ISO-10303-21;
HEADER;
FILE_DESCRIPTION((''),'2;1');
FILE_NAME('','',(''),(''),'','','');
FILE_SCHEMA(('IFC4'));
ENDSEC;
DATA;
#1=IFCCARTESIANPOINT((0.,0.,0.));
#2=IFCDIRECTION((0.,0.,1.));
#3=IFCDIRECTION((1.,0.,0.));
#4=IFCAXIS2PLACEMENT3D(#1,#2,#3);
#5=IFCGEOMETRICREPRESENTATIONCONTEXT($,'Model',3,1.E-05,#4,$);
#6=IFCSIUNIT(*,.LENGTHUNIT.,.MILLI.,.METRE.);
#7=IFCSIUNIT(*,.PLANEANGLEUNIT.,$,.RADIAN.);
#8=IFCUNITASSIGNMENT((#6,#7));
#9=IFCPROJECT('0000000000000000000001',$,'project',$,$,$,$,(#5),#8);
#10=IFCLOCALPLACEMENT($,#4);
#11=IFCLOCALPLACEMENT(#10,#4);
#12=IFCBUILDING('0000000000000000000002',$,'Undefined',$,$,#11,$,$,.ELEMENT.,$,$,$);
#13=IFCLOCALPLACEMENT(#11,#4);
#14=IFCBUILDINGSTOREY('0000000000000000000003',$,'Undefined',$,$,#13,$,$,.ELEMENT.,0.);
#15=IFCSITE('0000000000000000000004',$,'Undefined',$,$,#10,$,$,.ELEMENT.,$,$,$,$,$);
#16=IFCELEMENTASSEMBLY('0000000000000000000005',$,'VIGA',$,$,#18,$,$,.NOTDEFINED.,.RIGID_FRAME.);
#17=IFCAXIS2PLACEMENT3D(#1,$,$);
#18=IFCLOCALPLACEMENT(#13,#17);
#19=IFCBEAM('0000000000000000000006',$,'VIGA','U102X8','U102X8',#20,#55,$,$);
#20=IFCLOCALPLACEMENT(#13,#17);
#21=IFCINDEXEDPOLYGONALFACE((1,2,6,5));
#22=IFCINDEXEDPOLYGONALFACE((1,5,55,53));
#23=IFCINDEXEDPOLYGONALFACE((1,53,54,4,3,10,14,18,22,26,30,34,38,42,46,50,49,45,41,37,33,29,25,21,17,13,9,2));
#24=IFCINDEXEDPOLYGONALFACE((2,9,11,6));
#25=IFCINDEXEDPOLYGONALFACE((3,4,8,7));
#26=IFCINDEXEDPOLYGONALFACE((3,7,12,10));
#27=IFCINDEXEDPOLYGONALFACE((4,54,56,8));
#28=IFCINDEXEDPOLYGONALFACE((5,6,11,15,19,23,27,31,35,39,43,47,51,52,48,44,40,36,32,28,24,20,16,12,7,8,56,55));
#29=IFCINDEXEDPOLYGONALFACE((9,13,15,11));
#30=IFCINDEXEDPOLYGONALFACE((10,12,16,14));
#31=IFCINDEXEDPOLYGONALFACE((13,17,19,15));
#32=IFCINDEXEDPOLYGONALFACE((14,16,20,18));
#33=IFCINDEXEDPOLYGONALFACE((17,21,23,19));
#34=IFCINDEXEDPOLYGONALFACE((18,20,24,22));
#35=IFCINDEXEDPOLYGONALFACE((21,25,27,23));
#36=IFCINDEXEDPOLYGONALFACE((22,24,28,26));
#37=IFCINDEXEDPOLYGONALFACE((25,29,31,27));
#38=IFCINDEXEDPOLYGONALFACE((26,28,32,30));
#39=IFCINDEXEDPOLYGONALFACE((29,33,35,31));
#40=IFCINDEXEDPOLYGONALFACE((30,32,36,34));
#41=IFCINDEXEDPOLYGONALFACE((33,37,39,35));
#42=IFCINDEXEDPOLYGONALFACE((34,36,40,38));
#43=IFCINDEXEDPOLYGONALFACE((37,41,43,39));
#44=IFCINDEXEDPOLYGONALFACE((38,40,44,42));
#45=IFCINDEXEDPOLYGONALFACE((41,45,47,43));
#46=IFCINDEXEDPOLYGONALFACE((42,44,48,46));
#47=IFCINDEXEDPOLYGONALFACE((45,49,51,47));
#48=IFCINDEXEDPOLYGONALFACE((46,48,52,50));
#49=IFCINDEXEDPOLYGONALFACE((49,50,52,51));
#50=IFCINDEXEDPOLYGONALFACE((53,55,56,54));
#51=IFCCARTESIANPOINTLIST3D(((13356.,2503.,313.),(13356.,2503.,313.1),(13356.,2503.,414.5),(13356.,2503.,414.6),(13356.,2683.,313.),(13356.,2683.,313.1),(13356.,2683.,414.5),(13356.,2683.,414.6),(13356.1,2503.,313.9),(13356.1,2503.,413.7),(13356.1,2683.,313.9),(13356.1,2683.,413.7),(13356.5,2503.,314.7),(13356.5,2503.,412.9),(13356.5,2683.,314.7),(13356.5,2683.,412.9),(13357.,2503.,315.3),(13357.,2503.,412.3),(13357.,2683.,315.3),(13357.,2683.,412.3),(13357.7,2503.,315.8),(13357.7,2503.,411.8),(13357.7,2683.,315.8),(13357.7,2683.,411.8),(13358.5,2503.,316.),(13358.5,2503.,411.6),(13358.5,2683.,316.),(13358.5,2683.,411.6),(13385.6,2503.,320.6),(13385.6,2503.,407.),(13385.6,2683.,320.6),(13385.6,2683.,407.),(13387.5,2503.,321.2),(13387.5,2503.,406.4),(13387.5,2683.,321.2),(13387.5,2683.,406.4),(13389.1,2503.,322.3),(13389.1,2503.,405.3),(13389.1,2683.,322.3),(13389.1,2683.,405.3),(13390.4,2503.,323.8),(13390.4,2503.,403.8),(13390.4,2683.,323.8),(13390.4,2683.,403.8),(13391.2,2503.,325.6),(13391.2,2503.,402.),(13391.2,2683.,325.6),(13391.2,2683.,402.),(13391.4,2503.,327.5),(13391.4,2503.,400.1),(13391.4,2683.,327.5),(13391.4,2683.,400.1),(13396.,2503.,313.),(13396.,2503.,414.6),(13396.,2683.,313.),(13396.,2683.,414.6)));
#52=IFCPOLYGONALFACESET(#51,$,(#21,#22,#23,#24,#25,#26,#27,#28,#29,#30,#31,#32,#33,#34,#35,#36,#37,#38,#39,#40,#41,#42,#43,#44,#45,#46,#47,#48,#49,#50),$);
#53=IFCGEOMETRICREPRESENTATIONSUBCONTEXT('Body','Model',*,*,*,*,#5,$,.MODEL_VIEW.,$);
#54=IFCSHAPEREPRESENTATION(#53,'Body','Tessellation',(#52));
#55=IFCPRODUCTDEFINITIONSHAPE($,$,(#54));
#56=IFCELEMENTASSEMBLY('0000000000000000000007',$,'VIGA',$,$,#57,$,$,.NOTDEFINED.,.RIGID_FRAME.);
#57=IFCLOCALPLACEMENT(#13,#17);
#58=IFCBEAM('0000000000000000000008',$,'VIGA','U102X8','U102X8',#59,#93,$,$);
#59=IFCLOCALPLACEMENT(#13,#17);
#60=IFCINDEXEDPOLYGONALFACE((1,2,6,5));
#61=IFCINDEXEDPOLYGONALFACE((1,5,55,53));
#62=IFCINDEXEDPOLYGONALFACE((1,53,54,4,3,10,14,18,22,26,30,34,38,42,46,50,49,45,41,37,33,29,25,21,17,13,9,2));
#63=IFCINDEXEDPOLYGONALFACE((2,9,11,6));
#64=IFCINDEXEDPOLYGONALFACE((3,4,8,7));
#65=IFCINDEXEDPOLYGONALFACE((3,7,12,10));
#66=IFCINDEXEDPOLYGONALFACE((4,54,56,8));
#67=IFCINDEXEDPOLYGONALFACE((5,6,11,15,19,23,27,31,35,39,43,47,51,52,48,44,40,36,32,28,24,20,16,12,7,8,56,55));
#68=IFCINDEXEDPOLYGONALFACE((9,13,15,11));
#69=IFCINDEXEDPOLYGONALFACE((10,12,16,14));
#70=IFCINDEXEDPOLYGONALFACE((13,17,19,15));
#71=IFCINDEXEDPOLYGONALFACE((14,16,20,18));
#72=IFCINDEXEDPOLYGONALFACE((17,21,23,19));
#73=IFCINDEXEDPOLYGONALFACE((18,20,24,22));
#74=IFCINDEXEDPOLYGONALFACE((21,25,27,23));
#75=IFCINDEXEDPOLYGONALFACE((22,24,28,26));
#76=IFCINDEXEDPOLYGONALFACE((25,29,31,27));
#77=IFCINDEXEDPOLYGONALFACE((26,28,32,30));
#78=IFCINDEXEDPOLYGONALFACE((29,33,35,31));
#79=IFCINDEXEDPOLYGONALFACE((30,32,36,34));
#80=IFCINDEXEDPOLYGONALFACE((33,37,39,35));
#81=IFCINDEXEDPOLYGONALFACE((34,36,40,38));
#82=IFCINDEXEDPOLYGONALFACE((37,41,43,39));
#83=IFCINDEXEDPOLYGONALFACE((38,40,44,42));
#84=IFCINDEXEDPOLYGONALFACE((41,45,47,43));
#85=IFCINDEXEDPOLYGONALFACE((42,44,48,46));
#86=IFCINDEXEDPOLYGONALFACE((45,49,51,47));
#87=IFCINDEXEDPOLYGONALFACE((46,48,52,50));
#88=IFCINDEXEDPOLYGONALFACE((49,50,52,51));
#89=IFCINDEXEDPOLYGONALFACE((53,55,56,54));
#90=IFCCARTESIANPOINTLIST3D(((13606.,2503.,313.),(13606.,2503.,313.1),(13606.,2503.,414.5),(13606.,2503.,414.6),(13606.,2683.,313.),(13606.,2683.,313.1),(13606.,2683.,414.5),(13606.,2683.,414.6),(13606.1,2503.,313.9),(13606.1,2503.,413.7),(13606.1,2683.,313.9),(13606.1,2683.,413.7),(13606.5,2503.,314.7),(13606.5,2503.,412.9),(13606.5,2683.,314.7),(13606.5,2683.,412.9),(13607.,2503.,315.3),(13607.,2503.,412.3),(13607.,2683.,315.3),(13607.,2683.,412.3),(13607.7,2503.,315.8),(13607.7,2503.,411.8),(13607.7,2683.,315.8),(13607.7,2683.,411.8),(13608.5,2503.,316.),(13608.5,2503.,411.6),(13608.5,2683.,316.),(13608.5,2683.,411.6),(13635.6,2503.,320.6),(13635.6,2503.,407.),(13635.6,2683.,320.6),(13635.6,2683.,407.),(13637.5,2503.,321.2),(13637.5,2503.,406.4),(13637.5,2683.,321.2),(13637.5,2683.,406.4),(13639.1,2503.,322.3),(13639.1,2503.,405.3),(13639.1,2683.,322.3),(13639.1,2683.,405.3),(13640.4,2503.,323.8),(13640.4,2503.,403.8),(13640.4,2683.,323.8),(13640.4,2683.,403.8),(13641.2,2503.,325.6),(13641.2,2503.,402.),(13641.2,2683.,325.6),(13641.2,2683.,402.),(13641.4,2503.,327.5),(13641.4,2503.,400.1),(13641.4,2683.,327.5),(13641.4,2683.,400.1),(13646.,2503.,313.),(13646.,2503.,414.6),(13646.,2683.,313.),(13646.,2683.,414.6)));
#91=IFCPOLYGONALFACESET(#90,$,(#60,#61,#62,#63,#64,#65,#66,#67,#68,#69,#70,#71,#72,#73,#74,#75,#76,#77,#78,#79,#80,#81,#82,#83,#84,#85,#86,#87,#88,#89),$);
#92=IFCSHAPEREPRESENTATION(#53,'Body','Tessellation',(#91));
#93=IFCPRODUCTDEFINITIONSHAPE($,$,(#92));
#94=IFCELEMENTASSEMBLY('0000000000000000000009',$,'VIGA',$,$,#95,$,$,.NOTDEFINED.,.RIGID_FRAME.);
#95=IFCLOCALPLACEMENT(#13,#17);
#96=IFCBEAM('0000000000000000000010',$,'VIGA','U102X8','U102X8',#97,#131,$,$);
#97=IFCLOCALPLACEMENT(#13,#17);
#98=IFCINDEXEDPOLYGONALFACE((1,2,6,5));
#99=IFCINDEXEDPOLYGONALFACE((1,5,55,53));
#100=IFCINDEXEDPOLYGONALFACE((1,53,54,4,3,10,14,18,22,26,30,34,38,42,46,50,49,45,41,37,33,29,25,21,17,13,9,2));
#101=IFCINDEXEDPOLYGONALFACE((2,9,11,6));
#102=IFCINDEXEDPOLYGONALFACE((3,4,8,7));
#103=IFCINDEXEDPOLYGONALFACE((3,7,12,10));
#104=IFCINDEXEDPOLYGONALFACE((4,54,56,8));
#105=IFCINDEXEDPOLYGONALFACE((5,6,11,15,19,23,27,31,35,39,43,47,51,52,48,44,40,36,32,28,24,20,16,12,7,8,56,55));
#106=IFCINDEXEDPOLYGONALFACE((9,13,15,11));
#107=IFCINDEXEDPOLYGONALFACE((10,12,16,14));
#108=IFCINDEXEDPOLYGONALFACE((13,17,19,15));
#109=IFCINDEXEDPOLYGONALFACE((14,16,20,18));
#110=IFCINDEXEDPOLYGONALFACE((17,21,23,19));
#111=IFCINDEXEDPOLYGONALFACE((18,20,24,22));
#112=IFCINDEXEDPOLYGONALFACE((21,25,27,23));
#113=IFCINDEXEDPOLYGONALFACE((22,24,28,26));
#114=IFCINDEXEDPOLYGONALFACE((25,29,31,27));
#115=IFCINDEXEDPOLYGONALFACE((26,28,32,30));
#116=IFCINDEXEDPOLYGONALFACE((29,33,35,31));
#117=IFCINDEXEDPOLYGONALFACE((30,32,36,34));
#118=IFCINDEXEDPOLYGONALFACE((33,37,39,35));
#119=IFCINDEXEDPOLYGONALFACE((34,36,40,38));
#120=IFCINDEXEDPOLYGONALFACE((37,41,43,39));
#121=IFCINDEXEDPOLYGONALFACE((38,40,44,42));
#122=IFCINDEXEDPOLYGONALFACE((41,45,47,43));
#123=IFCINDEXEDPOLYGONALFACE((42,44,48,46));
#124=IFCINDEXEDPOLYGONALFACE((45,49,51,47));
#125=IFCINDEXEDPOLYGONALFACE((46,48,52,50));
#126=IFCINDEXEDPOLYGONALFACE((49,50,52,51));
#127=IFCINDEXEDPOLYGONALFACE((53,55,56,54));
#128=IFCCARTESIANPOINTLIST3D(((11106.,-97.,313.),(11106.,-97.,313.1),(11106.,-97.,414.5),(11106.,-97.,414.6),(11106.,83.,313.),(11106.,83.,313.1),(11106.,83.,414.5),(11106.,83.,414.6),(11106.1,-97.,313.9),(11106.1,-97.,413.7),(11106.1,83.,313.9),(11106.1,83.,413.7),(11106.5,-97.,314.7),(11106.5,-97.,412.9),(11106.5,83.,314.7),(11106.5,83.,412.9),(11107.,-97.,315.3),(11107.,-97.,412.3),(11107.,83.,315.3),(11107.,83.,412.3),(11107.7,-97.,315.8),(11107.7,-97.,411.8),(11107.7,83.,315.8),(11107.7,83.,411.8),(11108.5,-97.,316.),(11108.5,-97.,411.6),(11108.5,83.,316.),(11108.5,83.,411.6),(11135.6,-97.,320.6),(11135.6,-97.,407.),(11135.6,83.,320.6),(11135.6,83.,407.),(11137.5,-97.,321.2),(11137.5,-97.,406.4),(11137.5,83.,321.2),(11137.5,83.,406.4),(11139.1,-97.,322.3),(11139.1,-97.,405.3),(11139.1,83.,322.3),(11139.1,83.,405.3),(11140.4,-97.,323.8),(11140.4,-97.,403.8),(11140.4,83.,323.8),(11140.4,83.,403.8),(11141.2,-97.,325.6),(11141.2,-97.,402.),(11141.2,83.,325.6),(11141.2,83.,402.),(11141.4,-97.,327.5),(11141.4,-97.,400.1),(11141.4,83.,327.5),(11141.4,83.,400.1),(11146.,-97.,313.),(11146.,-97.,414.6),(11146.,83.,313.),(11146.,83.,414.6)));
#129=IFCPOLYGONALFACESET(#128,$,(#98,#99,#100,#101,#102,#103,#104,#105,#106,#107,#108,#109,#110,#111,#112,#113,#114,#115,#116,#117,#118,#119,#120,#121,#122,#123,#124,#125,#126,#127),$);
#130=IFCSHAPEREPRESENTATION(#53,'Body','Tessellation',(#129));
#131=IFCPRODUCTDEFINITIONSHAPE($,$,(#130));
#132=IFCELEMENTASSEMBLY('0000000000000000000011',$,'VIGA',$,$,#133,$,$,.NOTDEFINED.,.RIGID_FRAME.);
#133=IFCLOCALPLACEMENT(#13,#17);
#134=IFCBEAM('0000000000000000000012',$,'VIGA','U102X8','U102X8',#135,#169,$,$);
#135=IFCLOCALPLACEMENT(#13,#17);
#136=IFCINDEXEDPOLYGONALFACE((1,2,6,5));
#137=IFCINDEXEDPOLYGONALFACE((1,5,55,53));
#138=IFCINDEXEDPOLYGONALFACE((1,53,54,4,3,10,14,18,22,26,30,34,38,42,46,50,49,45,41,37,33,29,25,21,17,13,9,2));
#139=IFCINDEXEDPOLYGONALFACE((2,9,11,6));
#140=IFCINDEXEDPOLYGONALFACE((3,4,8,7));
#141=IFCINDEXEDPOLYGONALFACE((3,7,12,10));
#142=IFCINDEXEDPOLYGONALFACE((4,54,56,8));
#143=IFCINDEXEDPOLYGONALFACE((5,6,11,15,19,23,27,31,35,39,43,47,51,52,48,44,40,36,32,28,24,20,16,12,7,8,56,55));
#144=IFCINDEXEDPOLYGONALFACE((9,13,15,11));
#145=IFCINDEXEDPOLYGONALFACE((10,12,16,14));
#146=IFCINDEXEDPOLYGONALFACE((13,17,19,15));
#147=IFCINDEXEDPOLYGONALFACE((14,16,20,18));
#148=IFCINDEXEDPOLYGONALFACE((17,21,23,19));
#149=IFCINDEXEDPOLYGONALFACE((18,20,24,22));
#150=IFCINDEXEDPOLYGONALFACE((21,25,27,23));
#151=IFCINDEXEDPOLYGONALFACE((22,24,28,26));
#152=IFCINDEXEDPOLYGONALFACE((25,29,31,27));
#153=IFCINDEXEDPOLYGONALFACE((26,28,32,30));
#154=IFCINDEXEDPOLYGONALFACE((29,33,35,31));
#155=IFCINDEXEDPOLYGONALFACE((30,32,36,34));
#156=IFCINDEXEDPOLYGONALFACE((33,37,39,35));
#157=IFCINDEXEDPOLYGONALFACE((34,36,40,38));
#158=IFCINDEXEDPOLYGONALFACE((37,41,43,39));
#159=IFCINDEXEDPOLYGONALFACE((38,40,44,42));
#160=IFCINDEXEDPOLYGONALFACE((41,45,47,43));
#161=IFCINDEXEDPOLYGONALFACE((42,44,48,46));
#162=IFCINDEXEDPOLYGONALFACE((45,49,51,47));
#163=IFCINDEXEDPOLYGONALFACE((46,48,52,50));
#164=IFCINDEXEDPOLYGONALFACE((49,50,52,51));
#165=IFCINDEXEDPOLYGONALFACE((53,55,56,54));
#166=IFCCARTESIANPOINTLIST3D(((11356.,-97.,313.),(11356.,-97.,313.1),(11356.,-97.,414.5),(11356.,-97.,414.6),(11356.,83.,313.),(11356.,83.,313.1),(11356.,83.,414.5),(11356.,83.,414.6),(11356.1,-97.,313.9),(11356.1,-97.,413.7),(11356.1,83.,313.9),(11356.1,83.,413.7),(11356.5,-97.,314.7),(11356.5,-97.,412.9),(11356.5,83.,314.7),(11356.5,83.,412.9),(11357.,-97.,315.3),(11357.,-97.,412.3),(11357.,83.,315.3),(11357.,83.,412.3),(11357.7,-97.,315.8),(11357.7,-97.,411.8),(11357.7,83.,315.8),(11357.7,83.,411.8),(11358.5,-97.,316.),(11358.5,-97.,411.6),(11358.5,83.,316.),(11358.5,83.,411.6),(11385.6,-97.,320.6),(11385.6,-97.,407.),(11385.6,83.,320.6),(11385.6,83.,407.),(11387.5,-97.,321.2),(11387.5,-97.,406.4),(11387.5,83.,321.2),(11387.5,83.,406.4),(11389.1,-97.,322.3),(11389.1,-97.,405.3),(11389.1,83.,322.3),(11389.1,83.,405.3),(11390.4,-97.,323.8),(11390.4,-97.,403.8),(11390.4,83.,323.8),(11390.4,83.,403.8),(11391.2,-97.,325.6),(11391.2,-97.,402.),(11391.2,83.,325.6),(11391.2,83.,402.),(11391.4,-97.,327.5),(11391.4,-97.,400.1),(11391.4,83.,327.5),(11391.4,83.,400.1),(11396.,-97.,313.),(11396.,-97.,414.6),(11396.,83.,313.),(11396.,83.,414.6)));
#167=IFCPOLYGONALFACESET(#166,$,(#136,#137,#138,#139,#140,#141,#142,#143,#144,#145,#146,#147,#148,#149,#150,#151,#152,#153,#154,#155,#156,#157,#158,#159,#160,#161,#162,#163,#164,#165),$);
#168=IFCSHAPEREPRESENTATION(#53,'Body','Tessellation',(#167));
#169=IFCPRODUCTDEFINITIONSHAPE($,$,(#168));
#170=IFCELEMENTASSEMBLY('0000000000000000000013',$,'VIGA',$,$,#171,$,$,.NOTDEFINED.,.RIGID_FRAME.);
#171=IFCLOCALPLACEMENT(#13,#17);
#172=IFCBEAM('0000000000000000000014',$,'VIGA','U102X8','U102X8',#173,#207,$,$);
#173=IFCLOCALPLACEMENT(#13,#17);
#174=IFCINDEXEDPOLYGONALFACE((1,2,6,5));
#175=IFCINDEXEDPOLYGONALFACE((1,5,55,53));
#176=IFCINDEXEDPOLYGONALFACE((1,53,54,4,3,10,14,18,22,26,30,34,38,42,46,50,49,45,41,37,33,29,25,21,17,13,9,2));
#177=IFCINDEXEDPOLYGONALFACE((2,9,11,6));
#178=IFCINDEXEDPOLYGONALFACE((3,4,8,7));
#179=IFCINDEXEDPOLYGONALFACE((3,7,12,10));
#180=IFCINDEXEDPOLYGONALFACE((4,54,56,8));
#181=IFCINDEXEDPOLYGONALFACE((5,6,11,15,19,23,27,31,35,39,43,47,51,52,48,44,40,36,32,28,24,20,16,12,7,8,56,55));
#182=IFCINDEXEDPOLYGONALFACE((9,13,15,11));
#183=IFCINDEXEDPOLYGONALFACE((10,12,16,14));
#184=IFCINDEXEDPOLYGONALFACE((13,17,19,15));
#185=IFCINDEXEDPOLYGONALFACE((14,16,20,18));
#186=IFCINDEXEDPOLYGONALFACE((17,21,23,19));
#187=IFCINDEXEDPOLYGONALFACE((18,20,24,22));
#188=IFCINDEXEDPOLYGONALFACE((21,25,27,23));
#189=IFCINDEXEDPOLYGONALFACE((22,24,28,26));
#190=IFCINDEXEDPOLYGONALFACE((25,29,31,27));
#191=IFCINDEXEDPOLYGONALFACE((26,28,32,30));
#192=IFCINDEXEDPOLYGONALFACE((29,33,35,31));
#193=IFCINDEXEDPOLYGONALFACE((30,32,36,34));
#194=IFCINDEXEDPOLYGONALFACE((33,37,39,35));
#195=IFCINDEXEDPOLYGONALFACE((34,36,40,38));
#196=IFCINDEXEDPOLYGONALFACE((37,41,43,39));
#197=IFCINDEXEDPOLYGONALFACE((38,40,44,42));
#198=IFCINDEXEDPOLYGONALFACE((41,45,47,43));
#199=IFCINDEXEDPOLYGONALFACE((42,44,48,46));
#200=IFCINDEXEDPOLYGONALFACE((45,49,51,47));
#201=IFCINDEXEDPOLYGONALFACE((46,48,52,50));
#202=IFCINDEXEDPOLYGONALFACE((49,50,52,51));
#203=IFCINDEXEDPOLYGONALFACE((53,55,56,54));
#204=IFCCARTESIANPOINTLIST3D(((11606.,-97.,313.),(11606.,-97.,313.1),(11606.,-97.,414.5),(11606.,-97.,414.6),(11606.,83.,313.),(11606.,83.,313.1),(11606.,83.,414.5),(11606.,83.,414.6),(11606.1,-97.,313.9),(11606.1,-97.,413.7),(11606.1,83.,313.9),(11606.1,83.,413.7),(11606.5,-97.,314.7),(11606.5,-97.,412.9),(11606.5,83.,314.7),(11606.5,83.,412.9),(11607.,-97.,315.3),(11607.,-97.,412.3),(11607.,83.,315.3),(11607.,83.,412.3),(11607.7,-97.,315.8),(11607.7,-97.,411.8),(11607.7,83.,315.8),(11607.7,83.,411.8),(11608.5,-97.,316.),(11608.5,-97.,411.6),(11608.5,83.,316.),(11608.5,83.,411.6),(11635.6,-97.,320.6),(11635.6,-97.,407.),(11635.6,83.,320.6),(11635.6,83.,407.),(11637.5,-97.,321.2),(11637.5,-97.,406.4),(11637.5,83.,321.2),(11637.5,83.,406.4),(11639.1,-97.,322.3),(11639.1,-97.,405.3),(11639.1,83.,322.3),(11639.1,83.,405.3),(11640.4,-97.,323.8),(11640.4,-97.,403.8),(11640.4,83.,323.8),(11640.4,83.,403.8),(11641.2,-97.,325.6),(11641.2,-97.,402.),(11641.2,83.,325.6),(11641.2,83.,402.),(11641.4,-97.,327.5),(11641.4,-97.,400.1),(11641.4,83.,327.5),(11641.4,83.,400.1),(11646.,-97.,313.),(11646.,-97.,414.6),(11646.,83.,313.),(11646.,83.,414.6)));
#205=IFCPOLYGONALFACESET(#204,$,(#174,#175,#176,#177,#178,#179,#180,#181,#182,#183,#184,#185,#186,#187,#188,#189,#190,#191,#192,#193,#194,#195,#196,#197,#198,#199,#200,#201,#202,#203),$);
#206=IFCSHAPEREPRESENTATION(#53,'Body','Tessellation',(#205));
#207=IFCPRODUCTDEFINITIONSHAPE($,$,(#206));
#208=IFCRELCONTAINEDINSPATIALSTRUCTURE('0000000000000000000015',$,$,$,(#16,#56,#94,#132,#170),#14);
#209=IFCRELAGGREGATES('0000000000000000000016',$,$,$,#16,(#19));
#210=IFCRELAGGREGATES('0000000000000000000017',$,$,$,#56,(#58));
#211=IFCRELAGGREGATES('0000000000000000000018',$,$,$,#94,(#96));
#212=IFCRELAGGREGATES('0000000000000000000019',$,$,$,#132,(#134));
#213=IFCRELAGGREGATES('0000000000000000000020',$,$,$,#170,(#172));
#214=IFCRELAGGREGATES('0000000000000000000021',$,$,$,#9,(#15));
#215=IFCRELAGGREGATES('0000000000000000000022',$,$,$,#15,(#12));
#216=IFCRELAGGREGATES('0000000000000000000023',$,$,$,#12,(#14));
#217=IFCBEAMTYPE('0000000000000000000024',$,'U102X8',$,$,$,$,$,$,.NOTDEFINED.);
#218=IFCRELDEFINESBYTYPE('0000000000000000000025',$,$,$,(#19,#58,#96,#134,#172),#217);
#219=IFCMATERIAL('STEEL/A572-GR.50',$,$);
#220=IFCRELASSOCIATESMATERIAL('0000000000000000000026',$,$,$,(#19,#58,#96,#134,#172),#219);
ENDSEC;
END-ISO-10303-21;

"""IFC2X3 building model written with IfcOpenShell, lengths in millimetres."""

from ifc_helpers import new_model, si_unit, frame, origin_with_axes, origin_2d_with_axis, place, context, subcontext, project, spatial, u_section, extrude, material, type_object, element, aggregate, save


model = new_model("IFC2X3")

# Units and contexts
model_context = context("Model", 3, precision=1e-05, world=origin_with_axes())
body_context = subcontext(model_context, "Body", "Model", "MODEL_VIEW")
ifc_project = project(units=[si_unit("LENGTHUNIT", "METRE", prefix="MILLI"), si_unit("PLANEANGLEUNIT", "RADIAN")], contexts=[model_context])

# Site, building, storey
site_placement = place(None, origin_with_axes())
site = spatial("IfcSite", under=ifc_project, at=site_placement, Name="Undefined", CompositionType="ELEMENT")
building_placement = place(site_placement, origin_with_axes())
building = spatial("IfcBuilding", under=site, at=building_placement, Name="Undefined", CompositionType="ELEMENT")
storey_placement = place(building_placement, origin_with_axes())
storey = spatial("IfcBuildingStorey", under=building, at=storey_placement, Name="Undefined", CompositionType="ELEMENT", Elevation=0.0)

# Element assemblies, beams
ifc_material = material(Name="STEEL/A572-GR.50")
beam_type = type_object("IfcBeamType", Name="U102X8", PredefinedType="NOTDEFINED")
assembly_1_placement = place(storey_placement, origin_with_axes())
assembly_1 = element("IfcElementAssembly", 1, at=assembly_1_placement, inside=storey, Name="VIGA", AssemblyPlace="NOTDEFINED", PredefinedType="RIGID_FRAME")
beam_1_placement = place(assembly_1_placement, frame((13376.0, 2683.0, 363.8), z_axis=(0.0, 0.0, 1.0), x_axis=(0.0, -1.0, 0.0)))
beam_1 = element("IfcBeam", 2, at=beam_1_placement, type_object=beam_type, material=ifc_material, Name="VIGA", Description="U102X8", ObjectType="U102X8", context=body_context, shape_type="SweptSolid", body=[
    extrude(u_section(Depth=101.6, FlangeWidth=40.0, WebThickness=4.6, FlangeThickness=6.0, FilletRadius=7.0, EdgeRadius=3.0, FlangeSlope=0.16839, at=origin_2d_with_axis()), frame((180.0, 0.0, 0.0), z_axis=(-1.0, 0.0, 0.0), x_axis=(0.0, -1.0, 0.0)), (0.0, 0.0, 1.0), 180.0),
])
aggregate(assembly_1, [beam_1])
assembly_2_placement = place(storey_placement, origin_with_axes())
assembly_2 = element("IfcElementAssembly", 3, at=assembly_2_placement, inside=storey, Name="VIGA", AssemblyPlace="NOTDEFINED", PredefinedType="RIGID_FRAME")
beam_2_placement = place(assembly_2_placement, frame((13626.0, 2683.0, 363.8), z_axis=(0.0, 0.0, 1.0), x_axis=(0.0, -1.0, 0.0)))
beam_2 = element("IfcBeam", 4, at=beam_2_placement, type_object=beam_type, material=ifc_material, Name="VIGA", Description="U102X8", ObjectType="U102X8", context=body_context, shape_type="SweptSolid", body=[
    extrude(u_section(Depth=101.6, FlangeWidth=40.0, WebThickness=4.6, FlangeThickness=6.0, FilletRadius=7.0, EdgeRadius=3.0, FlangeSlope=0.16839, at=origin_2d_with_axis()), frame((180.0, 0.0, 0.0), z_axis=(-1.0, 0.0, 0.0), x_axis=(0.0, -1.0, 0.0)), (0.0, 0.0, 1.0), 180.0),
])
aggregate(assembly_2, [beam_2])
assembly_3_placement = place(storey_placement, origin_with_axes())
assembly_3 = element("IfcElementAssembly", 5, at=assembly_3_placement, inside=storey, Name="VIGA", AssemblyPlace="NOTDEFINED", PredefinedType="RIGID_FRAME")
beam_3_placement = place(assembly_3_placement, frame((11126.0, 83.0, 363.8), z_axis=(0.0, 0.0, 1.0), x_axis=(0.0, -1.0, 0.0)))
beam_3 = element("IfcBeam", 6, at=beam_3_placement, type_object=beam_type, material=ifc_material, Name="VIGA", Description="U102X8", ObjectType="U102X8", context=body_context, shape_type="SweptSolid", body=[
    extrude(u_section(Depth=101.6, FlangeWidth=40.0, WebThickness=4.6, FlangeThickness=6.0, FilletRadius=7.0, EdgeRadius=3.0, FlangeSlope=0.16839, at=origin_2d_with_axis()), frame((180.0, 0.0, 0.0), z_axis=(-1.0, 0.0, 0.0), x_axis=(0.0, -1.0, 0.0)), (0.0, 0.0, 1.0), 180.0),
])
aggregate(assembly_3, [beam_3])
assembly_4_placement = place(storey_placement, origin_with_axes())
assembly_4 = element("IfcElementAssembly", 7, at=assembly_4_placement, inside=storey, Name="VIGA", AssemblyPlace="NOTDEFINED", PredefinedType="RIGID_FRAME")
beam_4_placement = place(assembly_4_placement, frame((11376.0, 83.0, 363.8), z_axis=(0.0, 0.0, 1.0), x_axis=(0.0, -1.0, 0.0)))
beam_4 = element("IfcBeam", 8, at=beam_4_placement, type_object=beam_type, material=ifc_material, Name="VIGA", Description="U102X8", ObjectType="U102X8", context=body_context, shape_type="SweptSolid", body=[
    extrude(u_section(Depth=101.6, FlangeWidth=40.0, WebThickness=4.6, FlangeThickness=6.0, FilletRadius=7.0, EdgeRadius=3.0, FlangeSlope=0.16839, at=origin_2d_with_axis()), frame((180.0, 0.0, 0.0), z_axis=(-1.0, 0.0, 0.0), x_axis=(0.0, -1.0, 0.0)), (0.0, 0.0, 1.0), 180.0),
])
aggregate(assembly_4, [beam_4])
assembly_5_placement = place(storey_placement, origin_with_axes())
assembly_5 = element("IfcElementAssembly", 9, at=assembly_5_placement, inside=storey, Name="VIGA", AssemblyPlace="NOTDEFINED", PredefinedType="RIGID_FRAME")
beam_5_placement = place(assembly_5_placement, frame((11626.0, 83.0, 363.8), z_axis=(0.0, 0.0, 1.0), x_axis=(0.0, -1.0, 0.0)))
beam_5 = element("IfcBeam", 10, at=beam_5_placement, type_object=beam_type, material=ifc_material, Name="VIGA", Description="U102X8", ObjectType="U102X8", context=body_context, shape_type="SweptSolid", body=[
    extrude(u_section(Depth=101.6, FlangeWidth=40.0, WebThickness=4.6, FlangeThickness=6.0, FilletRadius=7.0, EdgeRadius=3.0, FlangeSlope=0.16839, at=origin_2d_with_axis()), frame((180.0, 0.0, 0.0), z_axis=(-1.0, 0.0, 0.0), x_axis=(0.0, -1.0, 0.0)), (0.0, 0.0, 1.0), 180.0),
])
aggregate(assembly_5, [beam_5])

save(model, "model.ifc")
